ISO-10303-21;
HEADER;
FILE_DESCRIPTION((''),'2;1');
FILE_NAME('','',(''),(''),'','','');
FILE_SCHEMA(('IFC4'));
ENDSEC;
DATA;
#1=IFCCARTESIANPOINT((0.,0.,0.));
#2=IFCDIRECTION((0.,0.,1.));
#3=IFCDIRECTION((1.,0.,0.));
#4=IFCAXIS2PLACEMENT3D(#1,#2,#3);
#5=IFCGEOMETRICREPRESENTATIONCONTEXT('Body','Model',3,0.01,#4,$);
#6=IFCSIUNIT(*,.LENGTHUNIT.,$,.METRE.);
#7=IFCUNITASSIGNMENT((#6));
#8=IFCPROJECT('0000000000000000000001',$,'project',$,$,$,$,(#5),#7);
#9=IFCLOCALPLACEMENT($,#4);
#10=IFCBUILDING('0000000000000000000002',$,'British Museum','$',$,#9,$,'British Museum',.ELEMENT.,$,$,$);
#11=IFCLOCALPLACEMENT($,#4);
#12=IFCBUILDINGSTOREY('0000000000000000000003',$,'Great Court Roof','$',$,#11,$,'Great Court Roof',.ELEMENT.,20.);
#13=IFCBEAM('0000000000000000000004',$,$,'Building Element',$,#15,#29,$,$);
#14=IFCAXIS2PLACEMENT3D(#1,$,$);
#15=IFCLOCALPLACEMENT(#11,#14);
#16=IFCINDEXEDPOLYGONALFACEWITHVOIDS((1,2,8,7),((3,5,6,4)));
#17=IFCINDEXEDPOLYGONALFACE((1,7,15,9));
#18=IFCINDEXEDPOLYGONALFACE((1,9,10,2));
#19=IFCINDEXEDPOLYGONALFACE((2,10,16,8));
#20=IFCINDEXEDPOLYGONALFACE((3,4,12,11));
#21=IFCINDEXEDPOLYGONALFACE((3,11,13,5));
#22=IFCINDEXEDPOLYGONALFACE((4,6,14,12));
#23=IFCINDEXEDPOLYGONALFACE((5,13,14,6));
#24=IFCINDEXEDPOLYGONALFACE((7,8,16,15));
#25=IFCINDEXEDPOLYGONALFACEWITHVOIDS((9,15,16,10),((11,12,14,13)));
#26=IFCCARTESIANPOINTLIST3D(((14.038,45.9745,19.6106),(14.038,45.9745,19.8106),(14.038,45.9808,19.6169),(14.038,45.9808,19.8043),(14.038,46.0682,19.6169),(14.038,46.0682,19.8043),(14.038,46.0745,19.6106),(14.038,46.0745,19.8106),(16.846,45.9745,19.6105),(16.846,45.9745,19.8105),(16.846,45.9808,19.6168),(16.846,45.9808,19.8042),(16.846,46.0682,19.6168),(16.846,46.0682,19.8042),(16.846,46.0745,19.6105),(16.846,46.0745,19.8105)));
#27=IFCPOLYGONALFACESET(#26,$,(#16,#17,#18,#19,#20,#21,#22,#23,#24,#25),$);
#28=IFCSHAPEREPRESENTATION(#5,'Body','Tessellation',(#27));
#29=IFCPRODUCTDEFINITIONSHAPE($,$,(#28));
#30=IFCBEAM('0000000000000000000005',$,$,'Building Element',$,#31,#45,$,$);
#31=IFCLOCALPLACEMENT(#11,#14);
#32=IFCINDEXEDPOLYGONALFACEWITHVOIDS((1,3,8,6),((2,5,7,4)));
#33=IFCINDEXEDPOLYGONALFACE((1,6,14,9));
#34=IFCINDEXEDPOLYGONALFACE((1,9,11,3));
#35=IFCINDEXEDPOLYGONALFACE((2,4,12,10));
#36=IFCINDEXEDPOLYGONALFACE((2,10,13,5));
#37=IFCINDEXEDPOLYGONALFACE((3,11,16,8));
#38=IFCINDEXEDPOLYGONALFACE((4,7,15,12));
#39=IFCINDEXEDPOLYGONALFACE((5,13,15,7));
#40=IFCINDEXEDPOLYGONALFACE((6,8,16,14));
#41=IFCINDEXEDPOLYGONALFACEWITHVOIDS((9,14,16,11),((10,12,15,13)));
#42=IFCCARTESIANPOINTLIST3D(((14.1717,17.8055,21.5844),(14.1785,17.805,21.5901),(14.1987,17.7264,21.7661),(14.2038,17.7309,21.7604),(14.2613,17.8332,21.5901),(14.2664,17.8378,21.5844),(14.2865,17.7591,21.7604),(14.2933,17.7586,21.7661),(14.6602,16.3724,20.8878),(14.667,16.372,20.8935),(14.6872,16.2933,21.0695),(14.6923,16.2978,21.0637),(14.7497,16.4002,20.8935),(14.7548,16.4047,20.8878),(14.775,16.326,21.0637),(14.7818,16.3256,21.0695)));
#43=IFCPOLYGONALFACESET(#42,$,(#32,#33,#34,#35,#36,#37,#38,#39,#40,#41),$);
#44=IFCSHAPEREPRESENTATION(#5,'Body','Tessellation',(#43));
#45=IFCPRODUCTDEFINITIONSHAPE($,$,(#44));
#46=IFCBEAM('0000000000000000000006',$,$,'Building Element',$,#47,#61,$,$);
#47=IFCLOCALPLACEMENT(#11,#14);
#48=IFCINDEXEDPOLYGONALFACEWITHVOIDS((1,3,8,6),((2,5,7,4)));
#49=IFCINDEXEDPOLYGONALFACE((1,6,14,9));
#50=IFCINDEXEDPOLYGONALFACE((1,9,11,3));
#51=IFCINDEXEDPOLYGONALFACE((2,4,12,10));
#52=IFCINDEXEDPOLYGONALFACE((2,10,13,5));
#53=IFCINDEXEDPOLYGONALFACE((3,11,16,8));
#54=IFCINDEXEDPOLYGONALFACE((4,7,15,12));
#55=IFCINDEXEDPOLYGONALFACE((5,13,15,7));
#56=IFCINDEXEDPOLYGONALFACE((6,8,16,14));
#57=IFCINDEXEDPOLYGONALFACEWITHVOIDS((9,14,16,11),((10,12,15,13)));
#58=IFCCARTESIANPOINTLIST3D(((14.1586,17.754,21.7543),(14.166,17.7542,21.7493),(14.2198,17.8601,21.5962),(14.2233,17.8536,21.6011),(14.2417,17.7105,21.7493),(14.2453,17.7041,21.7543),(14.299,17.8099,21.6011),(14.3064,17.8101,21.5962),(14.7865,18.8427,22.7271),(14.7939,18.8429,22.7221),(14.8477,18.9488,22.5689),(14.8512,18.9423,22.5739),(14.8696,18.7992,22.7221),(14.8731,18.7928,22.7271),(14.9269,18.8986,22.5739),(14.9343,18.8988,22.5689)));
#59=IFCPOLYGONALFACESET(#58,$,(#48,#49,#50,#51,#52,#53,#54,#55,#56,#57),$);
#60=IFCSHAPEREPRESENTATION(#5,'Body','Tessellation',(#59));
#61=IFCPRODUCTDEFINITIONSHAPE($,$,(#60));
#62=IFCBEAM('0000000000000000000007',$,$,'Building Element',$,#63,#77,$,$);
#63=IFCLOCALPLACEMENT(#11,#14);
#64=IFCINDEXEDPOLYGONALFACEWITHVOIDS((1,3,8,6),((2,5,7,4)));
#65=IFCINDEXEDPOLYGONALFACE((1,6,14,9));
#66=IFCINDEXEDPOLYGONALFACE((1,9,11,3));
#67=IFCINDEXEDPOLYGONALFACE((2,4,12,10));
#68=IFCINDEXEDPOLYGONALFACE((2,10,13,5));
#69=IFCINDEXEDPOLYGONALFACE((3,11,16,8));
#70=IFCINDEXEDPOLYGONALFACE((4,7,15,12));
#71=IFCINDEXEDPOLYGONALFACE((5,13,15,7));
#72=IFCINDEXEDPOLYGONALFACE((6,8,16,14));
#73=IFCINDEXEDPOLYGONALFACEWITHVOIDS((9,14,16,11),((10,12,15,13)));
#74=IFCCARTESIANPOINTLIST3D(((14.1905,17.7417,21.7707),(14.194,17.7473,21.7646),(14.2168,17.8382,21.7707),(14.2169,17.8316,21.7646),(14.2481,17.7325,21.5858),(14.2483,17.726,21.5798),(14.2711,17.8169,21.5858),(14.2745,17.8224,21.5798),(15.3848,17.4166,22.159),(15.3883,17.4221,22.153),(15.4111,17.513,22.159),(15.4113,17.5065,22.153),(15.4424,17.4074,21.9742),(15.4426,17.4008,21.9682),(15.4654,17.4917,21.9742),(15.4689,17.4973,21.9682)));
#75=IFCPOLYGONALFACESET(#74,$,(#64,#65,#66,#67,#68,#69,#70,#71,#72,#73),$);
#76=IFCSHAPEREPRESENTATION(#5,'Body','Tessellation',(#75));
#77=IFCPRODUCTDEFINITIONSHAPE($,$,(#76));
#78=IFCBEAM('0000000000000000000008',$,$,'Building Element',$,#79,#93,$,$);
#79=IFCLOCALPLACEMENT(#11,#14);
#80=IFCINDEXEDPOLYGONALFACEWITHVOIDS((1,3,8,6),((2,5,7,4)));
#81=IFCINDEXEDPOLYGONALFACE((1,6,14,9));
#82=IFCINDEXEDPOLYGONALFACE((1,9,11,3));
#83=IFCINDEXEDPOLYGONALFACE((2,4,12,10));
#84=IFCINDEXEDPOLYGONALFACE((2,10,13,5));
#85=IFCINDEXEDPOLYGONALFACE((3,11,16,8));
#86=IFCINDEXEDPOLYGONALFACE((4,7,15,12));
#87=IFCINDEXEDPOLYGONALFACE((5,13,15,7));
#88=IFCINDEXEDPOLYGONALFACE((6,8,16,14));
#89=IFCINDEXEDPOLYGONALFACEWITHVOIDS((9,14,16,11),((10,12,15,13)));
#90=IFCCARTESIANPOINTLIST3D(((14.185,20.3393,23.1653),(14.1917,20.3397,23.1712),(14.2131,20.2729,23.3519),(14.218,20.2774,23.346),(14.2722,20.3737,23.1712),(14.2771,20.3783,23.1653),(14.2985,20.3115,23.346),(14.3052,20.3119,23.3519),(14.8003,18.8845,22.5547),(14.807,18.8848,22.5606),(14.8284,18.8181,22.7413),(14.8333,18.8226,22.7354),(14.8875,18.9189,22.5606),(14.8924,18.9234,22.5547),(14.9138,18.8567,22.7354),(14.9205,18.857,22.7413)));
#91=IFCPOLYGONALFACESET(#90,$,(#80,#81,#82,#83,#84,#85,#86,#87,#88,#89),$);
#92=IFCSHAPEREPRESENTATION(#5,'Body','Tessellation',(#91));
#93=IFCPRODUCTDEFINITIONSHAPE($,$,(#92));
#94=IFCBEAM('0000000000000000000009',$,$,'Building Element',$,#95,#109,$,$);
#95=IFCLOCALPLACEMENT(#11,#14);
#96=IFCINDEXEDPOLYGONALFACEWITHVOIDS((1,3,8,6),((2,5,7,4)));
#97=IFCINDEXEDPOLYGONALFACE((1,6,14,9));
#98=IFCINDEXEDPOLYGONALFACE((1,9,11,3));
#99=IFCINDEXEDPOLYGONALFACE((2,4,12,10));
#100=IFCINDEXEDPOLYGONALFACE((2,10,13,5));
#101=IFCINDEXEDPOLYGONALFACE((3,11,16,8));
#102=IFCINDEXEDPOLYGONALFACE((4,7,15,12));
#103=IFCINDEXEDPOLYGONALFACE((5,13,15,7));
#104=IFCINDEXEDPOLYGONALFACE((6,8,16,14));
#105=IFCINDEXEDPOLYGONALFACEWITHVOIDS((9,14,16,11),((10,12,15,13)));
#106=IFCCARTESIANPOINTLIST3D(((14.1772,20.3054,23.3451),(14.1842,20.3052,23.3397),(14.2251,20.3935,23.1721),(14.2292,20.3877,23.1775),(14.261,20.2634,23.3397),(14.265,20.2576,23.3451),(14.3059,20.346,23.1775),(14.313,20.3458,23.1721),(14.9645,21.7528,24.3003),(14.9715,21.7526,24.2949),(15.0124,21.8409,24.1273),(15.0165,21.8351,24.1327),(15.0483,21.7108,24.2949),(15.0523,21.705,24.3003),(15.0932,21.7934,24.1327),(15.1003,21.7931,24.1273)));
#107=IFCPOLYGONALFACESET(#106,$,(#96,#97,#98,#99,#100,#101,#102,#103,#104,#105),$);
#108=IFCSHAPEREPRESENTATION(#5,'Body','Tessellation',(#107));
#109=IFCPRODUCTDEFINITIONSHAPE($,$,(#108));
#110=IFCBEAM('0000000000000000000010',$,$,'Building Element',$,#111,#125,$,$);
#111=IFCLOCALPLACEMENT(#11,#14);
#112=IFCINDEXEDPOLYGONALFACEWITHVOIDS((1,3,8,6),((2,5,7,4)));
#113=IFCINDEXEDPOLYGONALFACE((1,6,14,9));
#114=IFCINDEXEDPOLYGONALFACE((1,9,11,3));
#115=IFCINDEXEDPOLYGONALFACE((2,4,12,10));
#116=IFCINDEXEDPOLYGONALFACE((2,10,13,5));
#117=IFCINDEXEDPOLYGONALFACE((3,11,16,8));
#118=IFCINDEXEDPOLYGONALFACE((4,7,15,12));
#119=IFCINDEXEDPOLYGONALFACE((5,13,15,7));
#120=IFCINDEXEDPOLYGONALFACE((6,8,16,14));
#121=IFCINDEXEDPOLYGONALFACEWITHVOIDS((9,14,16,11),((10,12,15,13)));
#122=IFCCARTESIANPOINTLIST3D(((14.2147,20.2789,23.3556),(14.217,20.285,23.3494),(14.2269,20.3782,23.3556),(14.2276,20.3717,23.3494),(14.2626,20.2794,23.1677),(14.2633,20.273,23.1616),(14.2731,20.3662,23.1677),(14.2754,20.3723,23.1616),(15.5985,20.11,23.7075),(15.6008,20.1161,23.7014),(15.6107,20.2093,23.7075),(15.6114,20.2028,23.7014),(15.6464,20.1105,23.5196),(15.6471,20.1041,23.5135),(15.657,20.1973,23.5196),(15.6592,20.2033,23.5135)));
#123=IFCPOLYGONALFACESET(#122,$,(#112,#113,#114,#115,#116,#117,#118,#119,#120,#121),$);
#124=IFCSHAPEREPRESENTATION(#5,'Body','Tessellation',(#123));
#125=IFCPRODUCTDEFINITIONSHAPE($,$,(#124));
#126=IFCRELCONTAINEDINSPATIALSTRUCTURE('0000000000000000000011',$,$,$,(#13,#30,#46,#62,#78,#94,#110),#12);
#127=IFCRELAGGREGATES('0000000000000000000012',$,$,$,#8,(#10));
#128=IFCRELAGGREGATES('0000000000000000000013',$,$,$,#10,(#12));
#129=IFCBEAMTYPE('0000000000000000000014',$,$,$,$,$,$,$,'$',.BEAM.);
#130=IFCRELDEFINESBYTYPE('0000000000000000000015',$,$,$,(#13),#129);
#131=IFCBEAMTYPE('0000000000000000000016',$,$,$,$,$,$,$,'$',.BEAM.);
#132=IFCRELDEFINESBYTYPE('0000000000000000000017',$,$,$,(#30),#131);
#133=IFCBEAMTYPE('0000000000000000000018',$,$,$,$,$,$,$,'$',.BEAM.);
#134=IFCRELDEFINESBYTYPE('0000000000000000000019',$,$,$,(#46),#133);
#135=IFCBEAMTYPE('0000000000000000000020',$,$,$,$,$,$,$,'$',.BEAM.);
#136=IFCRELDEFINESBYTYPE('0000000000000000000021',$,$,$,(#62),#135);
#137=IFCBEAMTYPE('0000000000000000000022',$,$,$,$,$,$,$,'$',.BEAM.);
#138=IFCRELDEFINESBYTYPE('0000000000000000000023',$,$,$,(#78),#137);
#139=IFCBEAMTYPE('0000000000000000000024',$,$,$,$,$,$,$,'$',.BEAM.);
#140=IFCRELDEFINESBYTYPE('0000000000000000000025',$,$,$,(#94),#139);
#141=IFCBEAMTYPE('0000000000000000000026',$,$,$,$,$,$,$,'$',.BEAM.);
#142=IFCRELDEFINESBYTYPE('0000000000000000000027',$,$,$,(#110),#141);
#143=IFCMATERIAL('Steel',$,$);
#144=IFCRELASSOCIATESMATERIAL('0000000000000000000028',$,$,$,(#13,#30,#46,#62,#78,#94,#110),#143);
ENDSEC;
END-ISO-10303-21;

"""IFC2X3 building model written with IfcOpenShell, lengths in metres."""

from ifc_helpers import new_model, si_unit, frame, origin_with_axes, origin_2d, place, context, project, spatial, hollow_rectangle, extrude, material, type_object, element, save


model = new_model("IFC2X3")

# Units and contexts
model_context = context("Model", 3, precision=0.01, world=origin_with_axes(), identifier="Body")
ifc_project = project(units=[si_unit("LENGTHUNIT", "METRE")], contexts=[model_context])

# Building, storey
building_placement = place(None, origin_with_axes())
building = spatial("IfcBuilding", under=ifc_project, at=building_placement, Name="British Museum", Description="$", LongName="British Museum", CompositionType="ELEMENT")
storey_placement = place(None, origin_with_axes())
storey = spatial("IfcBuildingStorey", under=building, at=storey_placement, Name="Great Court Roof", Description="$", LongName="Great Court Roof", CompositionType="ELEMENT", Elevation=20.0)

# Beams
ifc_material = material(Name="Steel")
beam_type_1 = type_object("IfcBeamType", ElementType="$", PredefinedType="BEAM")
beam_1_placement = place(None, origin_with_axes())
element("IfcBeam", 1, at=beam_1_placement, inside=storey, type_object=beam_type_1, material=ifc_material, Description="Building Element", context=model_context, shape_type="SweptSolid", body=[
    extrude(hollow_rectangle(XDim=0.1, YDim=0.2, WallThickness=0.0063, InnerFilletRadius=-0.0063, OuterFilletRadius=0.0, at=origin_2d()), frame((14.038, 46.0245, 19.7106), z_axis=(1.0, 0.0, -0.000007), x_axis=(0.0, 1.0, 0.0)), (0.0, 0.0, 1.0), 2.808),
])
beam_type_2 = type_object("IfcBeamType", ElementType="$", PredefinedType="BEAM")
beam_2_placement = place(None, origin_with_axes())
element("IfcBeam", 2, at=beam_2_placement, inside=storey, type_object=beam_type_2, material=ifc_material, Description="Building Element", context=model_context, shape_type="SweptSolid", body=[
    extrude(hollow_rectangle(XDim=0.1, YDim=0.2, WallThickness=0.0063, InnerFilletRadius=-0.0063, OuterFilletRadius=0.0, at=origin_2d()), frame((14.2325, 17.7821, 21.6752), z_axis=(0.293096, -0.859868, -0.417997), x_axis=(0.946524, 0.322634, 0.0)), (0.0, 0.0, 1.0), 1.6666),
])
beam_type_3 = type_object("IfcBeamType", ElementType="$", PredefinedType="BEAM")
beam_3_placement = place(None, origin_with_axes())
element("IfcBeam", 3, at=beam_3_placement, inside=storey, type_object=beam_type_3, material=ifc_material, Description="Building Element", context=model_context, shape_type="SweptSolid", body=[
    extrude(hollow_rectangle(XDim=0.1, YDim=0.2, WallThickness=0.0063, InnerFilletRadius=-0.0063, OuterFilletRadius=0.0, at=origin_2d()), frame((14.2325, 17.7821, 21.6752), z_axis=(0.395078, 0.685029, 0.612086), x_axis=(-0.866257, 0.499598, 0.0)), (0.0, 0.0, 1.0), 1.5893),
])
beam_type_4 = type_object("IfcBeamType", ElementType="$", PredefinedType="BEAM")
beam_4_placement = place(None, origin_with_axes())
element("IfcBeam", 4, at=beam_4_placement, inside=storey, type_object=beam_type_4, material=ifc_material, Description="Building Element", context=model_context, shape_type="SweptSolid", body=[
    extrude(hollow_rectangle(XDim=0.1, YDim=0.2, WallThickness=0.0063, InnerFilletRadius=-0.0063, OuterFilletRadius=0.0, at=origin_2d()), frame((14.2325, 17.7821, 21.6752), z_axis=(0.920632, -0.250618, 0.299378), x_axis=(0.262665, 0.964887, 0.0)), (0.0, 0.0, 1.0), 1.2973),
])
beam_type_5 = type_object("IfcBeamType", ElementType="$", PredefinedType="BEAM")
beam_5_placement = place(None, origin_with_axes())
element("IfcBeam", 5, at=beam_5_placement, inside=storey, type_object=beam_type_5, material=ifc_material, Description="Building Element", context=model_context, shape_type="SweptSolid", body=[
    extrude(hollow_rectangle(XDim=0.1, YDim=0.2, WallThickness=0.0063, InnerFilletRadius=-0.0063, OuterFilletRadius=0.0, at=origin_2d()), frame((14.2451, 20.3256, 23.2586), z_axis=(0.363338, -0.859064, -0.360546), x_axis=(0.92101, 0.389538, 0.0)), (0.0, 0.0, 1.0), 1.6935),
])
beam_type_6 = type_object("IfcBeamType", ElementType="$", PredefinedType="BEAM")
beam_6_placement = place(None, origin_with_axes())
element("IfcBeam", 6, at=beam_6_placement, inside=storey, type_object=beam_type_6, material=ifc_material, Description="Building Element", context=model_context, shape_type="SweptSolid", body=[
    extrude(hollow_rectangle(XDim=0.1, YDim=0.2, WallThickness=0.0063, InnerFilletRadius=-0.0063, OuterFilletRadius=0.0, at=origin_2d()), frame((14.2451, 20.3256, 23.2586), z_axis=(0.413382, 0.759979, 0.501545), x_axis=(-0.878455, 0.477825, 0.0)), (0.0, 0.0, 1.0), 1.9045),
])
beam_type_7 = type_object("IfcBeamType", ElementType="$", PredefinedType="BEAM")
beam_7_placement = place(None, origin_with_axes())
element("IfcBeam", 7, at=beam_7_placement, inside=storey, type_object=beam_type_7, material=ifc_material, Description="Building Element", context=model_context, shape_type="SweptSolid", body=[
    extrude(hollow_rectangle(XDim=0.1, YDim=0.2, WallThickness=0.0063, InnerFilletRadius=-0.0063, OuterFilletRadius=0.0, at=origin_2d()), frame((14.2451, 20.3256, 23.2586), z_axis=(0.962443, -0.117476, 0.244751), x_axis=(0.121161, 0.992633, 0.0)), (0.0, 0.0, 1.0), 1.4378),
])

save(model, "model.ifc")
